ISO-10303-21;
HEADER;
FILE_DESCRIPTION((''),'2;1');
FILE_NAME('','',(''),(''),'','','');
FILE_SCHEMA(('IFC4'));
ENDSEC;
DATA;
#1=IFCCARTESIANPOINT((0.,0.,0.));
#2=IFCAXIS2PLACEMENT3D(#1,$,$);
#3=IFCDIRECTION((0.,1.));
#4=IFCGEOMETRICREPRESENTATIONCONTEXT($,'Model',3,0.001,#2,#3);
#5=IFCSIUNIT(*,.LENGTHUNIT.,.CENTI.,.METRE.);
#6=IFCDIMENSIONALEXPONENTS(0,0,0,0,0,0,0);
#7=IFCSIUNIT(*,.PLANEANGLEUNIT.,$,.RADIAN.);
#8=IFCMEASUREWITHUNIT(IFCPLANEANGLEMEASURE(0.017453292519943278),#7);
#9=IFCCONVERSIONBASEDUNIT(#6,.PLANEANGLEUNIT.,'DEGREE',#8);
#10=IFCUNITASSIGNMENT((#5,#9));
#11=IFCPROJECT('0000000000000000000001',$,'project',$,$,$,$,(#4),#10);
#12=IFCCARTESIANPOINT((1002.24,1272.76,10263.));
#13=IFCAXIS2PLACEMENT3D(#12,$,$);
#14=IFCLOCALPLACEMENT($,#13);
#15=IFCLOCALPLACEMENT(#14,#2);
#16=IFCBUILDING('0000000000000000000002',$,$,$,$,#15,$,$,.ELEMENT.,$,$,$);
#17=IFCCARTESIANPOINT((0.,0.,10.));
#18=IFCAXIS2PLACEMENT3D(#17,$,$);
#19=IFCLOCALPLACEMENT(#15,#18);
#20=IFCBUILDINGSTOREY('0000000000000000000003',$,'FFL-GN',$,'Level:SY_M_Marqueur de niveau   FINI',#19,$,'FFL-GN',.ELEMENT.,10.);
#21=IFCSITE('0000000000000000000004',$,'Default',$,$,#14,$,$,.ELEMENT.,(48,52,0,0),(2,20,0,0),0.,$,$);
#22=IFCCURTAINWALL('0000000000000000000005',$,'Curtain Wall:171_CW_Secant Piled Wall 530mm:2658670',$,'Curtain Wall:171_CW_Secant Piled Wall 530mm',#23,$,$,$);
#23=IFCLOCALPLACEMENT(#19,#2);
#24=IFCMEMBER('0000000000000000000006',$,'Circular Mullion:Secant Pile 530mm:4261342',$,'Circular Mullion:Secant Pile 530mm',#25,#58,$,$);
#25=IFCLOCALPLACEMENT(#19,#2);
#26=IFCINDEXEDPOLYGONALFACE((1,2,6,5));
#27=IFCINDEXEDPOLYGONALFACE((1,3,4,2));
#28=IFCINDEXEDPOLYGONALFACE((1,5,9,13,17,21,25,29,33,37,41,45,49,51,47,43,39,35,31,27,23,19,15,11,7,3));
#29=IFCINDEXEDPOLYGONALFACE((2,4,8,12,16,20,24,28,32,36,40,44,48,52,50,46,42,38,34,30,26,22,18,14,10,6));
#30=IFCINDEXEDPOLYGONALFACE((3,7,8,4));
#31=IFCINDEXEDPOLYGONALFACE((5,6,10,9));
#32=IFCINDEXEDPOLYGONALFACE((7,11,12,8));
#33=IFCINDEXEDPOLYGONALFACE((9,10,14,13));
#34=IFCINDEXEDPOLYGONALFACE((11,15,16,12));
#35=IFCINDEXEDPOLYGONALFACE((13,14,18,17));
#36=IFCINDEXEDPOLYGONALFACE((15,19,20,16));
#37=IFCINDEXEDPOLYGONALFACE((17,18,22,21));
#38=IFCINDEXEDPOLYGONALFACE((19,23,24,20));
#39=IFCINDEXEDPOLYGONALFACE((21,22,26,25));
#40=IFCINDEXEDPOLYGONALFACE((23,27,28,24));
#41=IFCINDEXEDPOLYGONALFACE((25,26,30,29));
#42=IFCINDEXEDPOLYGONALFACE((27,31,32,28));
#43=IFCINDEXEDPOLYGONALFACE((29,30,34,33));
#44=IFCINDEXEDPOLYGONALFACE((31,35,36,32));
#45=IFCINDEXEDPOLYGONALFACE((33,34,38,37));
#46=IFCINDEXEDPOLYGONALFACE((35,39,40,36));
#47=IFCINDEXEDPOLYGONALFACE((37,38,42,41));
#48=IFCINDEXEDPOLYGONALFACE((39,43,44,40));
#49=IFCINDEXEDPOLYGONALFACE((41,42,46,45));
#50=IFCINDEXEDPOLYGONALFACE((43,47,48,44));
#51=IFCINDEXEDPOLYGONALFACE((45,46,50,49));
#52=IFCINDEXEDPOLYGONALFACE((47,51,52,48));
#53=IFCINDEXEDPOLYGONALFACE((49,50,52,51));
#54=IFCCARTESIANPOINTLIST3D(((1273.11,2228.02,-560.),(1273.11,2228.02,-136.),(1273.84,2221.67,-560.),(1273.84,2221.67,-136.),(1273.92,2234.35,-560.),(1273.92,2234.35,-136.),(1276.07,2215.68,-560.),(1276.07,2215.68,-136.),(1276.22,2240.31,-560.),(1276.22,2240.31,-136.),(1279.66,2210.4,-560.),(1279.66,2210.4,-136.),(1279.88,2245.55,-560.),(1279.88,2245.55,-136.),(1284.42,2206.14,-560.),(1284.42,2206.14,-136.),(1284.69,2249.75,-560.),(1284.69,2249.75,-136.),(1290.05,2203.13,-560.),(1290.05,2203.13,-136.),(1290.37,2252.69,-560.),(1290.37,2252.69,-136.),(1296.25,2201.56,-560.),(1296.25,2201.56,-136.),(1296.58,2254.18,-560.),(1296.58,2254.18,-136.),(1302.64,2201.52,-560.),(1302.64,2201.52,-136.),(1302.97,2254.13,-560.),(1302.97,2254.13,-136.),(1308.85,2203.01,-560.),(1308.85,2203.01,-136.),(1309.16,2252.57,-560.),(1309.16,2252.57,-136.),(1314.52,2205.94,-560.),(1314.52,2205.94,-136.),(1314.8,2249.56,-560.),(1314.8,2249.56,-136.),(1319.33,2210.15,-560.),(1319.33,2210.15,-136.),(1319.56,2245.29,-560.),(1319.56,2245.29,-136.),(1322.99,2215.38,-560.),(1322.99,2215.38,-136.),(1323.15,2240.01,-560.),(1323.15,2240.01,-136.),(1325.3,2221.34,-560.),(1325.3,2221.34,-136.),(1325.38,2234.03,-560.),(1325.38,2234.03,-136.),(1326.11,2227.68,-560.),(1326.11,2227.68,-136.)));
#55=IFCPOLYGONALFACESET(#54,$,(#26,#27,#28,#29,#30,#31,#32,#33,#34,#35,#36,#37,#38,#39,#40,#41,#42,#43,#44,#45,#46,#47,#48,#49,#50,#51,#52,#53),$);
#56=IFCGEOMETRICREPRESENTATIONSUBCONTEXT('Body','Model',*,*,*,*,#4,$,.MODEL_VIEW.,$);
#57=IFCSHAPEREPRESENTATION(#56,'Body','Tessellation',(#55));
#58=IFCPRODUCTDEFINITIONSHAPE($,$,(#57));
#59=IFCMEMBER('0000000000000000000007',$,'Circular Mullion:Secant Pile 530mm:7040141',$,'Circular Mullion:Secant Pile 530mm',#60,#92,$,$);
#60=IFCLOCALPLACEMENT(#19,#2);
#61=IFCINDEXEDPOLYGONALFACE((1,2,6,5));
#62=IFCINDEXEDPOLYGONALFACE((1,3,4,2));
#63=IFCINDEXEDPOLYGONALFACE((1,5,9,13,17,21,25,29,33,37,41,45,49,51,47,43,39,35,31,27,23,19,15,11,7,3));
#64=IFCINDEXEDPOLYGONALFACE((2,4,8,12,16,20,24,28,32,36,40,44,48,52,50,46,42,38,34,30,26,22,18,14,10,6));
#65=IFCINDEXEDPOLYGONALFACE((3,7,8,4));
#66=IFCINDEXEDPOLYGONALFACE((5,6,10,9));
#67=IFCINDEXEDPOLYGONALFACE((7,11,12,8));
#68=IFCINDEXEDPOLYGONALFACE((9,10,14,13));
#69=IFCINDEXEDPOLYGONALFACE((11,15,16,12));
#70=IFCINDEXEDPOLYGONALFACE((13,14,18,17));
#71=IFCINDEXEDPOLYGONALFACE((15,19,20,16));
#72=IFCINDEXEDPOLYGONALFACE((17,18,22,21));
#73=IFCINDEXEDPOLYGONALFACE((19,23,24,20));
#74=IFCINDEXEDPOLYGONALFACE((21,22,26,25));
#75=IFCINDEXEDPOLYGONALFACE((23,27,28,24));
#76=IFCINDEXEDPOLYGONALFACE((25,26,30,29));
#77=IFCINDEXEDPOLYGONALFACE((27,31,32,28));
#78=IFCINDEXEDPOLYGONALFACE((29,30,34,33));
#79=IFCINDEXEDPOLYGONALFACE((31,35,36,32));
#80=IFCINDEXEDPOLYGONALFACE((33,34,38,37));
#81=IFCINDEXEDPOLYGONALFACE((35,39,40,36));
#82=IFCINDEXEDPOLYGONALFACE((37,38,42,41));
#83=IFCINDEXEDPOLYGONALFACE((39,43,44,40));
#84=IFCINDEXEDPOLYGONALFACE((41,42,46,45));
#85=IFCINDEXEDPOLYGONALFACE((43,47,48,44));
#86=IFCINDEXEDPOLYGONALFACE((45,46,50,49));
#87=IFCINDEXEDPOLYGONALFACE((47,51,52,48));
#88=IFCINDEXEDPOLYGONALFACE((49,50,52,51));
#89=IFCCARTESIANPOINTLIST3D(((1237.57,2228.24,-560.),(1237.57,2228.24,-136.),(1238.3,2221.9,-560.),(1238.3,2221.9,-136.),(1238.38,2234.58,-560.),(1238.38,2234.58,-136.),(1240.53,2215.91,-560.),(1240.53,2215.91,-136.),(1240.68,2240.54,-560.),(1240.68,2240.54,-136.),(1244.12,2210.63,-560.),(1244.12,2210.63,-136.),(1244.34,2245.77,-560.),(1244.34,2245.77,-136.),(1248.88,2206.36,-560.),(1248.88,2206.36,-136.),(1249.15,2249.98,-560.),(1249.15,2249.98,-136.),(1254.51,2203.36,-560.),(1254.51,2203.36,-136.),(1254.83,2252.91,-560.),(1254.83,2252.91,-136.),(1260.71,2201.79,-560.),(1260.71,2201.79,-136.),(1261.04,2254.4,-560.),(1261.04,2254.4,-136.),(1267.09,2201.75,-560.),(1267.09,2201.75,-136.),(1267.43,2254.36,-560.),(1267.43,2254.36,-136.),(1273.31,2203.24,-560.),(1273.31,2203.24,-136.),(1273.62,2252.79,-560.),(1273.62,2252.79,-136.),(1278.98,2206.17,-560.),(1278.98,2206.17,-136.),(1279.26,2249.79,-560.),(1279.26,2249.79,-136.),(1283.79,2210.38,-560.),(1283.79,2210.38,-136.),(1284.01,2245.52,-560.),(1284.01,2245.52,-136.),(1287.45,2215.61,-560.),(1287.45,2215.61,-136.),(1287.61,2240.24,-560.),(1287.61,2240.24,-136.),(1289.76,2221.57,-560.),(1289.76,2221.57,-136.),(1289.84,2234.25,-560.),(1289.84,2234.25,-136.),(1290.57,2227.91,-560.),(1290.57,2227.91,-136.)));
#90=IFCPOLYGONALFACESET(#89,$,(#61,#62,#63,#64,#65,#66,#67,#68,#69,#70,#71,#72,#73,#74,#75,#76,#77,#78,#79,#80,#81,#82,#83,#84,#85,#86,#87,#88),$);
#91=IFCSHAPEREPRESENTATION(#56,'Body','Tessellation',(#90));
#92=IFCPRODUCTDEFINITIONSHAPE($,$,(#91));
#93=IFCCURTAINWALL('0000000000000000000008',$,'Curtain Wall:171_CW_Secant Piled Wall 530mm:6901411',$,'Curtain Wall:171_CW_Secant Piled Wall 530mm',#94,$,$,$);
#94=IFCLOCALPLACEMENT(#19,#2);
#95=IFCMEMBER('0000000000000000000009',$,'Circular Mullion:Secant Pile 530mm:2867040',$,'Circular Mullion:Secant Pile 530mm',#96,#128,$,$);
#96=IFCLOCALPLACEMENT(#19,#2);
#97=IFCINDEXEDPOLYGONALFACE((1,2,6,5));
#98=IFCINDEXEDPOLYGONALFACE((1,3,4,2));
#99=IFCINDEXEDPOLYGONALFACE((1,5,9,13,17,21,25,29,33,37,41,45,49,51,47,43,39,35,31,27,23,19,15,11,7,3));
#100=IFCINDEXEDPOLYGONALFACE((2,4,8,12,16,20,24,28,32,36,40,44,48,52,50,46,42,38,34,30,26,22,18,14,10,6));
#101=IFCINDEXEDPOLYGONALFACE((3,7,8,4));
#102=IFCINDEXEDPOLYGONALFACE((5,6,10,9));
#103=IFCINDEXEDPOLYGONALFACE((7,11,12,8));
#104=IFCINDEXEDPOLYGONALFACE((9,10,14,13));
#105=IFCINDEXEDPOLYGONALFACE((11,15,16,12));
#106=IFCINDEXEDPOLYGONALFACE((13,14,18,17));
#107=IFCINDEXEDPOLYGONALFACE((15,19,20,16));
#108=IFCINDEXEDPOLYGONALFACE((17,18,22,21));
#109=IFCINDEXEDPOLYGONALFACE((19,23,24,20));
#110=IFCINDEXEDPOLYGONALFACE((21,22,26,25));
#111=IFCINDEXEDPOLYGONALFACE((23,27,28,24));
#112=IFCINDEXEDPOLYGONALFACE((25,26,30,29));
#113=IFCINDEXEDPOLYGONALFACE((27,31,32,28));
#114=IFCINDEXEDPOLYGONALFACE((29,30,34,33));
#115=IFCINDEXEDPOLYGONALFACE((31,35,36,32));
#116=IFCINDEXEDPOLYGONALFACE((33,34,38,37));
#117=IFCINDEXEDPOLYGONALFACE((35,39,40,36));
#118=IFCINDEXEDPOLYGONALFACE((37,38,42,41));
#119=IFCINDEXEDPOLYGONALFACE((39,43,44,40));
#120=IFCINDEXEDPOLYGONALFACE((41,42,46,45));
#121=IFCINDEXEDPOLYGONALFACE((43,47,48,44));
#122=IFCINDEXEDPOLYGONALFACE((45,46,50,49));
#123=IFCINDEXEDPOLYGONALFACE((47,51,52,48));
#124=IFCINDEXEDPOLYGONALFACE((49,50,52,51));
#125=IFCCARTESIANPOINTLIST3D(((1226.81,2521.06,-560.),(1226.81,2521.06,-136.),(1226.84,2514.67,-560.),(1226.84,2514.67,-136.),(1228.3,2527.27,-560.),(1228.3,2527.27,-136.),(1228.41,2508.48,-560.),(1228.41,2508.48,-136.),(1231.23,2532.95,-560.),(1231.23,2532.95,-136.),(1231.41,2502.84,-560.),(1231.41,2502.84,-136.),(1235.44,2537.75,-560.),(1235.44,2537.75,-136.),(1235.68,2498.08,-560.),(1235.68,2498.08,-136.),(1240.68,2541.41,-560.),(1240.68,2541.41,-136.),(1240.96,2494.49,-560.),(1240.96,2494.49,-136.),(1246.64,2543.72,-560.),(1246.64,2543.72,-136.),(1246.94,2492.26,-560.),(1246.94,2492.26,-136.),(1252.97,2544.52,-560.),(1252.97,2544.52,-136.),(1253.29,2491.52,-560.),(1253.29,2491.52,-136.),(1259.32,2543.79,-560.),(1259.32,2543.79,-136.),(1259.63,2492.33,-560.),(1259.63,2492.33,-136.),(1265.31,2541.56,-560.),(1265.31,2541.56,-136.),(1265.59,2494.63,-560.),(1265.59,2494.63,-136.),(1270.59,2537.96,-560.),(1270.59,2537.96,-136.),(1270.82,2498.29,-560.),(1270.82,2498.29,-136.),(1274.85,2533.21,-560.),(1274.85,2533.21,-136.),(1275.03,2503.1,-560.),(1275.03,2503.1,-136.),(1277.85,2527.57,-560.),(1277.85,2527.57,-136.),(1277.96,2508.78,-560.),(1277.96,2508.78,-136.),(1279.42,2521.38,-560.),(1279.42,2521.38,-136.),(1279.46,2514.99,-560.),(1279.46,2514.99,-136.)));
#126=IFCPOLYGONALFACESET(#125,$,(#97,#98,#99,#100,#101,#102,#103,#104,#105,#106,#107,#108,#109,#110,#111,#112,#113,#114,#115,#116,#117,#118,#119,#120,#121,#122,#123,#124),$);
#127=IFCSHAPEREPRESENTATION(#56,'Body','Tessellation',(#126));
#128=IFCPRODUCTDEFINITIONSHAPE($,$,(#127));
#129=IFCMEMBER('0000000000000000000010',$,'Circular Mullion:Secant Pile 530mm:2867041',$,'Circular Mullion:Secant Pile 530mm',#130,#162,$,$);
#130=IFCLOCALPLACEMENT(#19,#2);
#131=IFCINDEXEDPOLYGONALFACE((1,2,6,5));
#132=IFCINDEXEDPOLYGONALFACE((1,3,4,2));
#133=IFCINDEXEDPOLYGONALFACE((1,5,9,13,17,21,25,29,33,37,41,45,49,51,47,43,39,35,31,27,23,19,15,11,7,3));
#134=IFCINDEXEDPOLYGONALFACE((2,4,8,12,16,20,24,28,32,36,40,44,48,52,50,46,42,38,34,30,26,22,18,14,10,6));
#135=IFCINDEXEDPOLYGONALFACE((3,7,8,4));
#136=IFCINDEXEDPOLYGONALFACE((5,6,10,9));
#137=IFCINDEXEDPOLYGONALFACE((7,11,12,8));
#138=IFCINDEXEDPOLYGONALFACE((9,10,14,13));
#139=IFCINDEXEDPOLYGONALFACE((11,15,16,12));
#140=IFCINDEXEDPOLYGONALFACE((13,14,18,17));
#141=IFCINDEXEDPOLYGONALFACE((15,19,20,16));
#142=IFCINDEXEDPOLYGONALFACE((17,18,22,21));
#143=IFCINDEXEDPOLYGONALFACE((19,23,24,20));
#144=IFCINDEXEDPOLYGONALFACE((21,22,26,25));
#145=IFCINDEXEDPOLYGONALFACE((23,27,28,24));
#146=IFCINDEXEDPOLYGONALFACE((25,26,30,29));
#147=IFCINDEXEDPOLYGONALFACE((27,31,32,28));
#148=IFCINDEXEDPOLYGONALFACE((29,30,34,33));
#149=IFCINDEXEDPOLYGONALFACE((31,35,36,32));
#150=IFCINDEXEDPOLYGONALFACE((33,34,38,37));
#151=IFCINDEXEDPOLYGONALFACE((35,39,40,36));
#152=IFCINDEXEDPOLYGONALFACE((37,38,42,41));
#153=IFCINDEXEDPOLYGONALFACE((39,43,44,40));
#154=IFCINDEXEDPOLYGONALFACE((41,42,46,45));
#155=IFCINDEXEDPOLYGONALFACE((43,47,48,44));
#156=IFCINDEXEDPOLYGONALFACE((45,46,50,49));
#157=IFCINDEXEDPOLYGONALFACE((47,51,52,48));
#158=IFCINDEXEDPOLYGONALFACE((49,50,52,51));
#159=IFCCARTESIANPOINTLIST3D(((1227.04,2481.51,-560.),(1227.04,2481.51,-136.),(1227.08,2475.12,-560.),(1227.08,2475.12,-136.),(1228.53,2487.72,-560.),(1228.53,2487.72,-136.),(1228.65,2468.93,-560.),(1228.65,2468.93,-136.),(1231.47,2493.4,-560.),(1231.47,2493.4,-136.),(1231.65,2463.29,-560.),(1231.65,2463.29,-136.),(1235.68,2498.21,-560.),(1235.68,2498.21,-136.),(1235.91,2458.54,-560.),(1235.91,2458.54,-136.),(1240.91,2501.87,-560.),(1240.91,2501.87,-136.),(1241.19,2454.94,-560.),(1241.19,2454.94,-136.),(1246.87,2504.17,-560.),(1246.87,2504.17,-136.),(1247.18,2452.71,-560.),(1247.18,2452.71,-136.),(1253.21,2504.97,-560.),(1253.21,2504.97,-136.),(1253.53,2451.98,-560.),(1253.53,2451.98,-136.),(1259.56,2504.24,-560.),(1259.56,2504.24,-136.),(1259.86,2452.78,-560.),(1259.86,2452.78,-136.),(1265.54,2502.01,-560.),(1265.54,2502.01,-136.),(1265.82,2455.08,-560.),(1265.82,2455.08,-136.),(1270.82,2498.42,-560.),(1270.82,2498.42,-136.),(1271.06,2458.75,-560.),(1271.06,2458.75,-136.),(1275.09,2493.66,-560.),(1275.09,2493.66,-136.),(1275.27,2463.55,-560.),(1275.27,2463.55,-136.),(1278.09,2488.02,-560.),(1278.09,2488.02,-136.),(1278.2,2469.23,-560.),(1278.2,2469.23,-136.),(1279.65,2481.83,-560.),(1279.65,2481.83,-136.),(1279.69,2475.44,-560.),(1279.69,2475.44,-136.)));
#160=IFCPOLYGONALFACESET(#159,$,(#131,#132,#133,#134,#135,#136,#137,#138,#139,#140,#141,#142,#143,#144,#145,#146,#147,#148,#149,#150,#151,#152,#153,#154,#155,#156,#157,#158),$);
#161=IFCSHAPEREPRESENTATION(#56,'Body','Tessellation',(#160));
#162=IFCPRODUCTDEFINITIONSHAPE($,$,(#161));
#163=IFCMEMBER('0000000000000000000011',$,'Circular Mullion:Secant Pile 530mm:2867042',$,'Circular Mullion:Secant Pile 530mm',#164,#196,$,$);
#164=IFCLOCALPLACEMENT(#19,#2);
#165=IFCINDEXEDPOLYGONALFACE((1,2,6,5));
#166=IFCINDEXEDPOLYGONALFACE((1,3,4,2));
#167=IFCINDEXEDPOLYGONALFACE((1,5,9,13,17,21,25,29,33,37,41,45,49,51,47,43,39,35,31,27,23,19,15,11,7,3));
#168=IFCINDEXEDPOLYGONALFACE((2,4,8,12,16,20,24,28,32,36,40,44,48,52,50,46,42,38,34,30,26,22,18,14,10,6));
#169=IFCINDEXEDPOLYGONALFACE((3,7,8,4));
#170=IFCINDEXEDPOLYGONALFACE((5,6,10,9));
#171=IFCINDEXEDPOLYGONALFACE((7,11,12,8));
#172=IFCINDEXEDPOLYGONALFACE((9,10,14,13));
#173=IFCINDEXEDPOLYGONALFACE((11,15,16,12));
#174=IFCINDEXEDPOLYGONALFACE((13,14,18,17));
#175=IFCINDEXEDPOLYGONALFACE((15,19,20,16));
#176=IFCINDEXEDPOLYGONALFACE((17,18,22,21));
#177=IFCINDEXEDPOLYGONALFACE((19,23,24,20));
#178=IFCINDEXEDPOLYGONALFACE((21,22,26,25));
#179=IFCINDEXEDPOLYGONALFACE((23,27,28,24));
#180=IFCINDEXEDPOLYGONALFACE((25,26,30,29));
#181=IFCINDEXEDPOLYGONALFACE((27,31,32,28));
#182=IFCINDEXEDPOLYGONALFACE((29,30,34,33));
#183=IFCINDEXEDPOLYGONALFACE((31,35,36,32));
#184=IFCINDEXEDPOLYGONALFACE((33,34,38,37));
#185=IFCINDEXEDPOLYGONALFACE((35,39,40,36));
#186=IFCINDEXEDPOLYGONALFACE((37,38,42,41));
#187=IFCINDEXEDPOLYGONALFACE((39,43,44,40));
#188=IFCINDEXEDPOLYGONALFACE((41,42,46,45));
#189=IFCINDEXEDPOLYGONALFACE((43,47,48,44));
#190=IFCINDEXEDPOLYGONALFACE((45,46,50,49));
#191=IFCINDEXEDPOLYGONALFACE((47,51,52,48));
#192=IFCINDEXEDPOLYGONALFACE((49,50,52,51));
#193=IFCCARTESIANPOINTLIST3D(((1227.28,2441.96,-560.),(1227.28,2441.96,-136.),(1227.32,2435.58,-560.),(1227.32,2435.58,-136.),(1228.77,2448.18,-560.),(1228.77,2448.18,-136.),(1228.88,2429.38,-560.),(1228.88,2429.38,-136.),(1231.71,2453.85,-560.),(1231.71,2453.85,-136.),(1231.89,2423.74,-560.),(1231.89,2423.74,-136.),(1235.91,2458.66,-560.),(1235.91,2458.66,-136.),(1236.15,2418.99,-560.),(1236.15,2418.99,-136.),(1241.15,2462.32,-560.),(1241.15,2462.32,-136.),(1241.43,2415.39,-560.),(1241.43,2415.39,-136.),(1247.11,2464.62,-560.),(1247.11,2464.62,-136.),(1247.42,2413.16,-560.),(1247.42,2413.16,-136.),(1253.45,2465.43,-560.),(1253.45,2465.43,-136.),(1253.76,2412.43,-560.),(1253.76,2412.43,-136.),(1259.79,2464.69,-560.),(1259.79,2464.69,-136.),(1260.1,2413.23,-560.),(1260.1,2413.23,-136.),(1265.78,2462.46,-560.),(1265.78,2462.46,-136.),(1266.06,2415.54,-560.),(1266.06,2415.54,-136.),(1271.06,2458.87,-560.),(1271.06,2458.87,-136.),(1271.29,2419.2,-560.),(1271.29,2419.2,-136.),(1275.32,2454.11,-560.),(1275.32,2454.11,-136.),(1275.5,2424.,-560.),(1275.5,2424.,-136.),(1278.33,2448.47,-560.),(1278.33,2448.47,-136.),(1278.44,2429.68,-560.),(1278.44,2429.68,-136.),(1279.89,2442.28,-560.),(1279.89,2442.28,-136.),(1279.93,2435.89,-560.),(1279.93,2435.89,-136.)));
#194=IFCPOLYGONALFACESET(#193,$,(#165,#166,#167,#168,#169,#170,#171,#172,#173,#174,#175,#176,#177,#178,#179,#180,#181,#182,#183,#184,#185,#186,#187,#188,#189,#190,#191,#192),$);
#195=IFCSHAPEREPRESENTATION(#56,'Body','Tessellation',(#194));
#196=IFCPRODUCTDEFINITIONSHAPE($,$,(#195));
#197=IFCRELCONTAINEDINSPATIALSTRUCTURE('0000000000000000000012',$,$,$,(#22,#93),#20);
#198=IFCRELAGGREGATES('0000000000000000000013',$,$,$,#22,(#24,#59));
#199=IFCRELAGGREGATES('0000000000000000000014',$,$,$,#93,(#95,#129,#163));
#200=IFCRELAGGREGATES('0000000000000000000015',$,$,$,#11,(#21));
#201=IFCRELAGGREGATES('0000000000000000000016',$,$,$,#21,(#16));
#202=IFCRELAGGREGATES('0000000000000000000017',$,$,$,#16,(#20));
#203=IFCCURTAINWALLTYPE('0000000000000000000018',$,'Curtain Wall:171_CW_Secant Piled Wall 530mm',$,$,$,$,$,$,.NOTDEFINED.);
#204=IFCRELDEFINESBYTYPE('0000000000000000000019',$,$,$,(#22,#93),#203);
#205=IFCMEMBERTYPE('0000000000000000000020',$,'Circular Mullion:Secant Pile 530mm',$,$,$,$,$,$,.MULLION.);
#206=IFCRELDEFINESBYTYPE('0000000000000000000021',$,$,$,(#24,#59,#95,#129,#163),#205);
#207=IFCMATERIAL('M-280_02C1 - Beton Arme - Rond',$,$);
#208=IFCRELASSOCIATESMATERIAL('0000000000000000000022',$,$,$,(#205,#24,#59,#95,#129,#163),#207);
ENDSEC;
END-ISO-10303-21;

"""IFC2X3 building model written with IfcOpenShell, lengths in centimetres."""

from ifc_helpers import new_model, entity, si_unit, converted_unit, direction, frame, frame_2d, origin, place, context, subcontext, project, spatial, circle, extrude, source, transform, mapped, material, type_object, type_shapes, element, aggregate, save


model = new_model("IFC2X3")

# Units and contexts
model_context = context("Model", 3, precision=0.001, world=origin(), true_north=direction((0.0, 1.0)))
body_context = subcontext(model_context, "Body", "Model", "MODEL_VIEW")
ifc_project = project(units=[si_unit("LENGTHUNIT", "METRE", prefix="CENTI"), converted_unit("PLANEANGLEUNIT", "DEGREE", entity("IfcPlaneAngleMeasure", 0.017453292519943278), si_unit("PLANEANGLEUNIT", "RADIAN"), dimensions=[0, 0, 0, 0, 0, 0, 0])], contexts=[model_context])

# Site, building, storey
site_placement = place(None, frame((1002.24, 1272.76, 10263.0)))
site = spatial("IfcSite", under=ifc_project, at=site_placement, Name="Default", CompositionType="ELEMENT", RefLatitude=(48, 52, 0, 0), RefLongitude=(2, 20, 0, 0), RefElevation=0.0)
building_placement = place(site_placement, origin())
building = spatial("IfcBuilding", under=site, at=building_placement, CompositionType="ELEMENT")
storey_placement = place(building_placement, frame((0.0, 0.0, 10.0)))
storey = spatial("IfcBuildingStorey", under=building, at=storey_placement, Name="FFL-GN", ObjectType="Level:SY_M_Marqueur de niveau   FINI", LongName="FFL-GN", CompositionType="ELEMENT", Elevation=10.0)

# Curtain walls, members
curtain_wall_type = type_object("IfcCurtainWallType", Name="Curtain Wall:171_CW_Secant Piled Wall 530mm", PredefinedType="NOTDEFINED")
ifc_material_1 = material(Name="M-280_02C1 - Beton Arme - Rond")
member_type = type_object("IfcMemberType", Name="Circular Mullion:Secant Pile 530mm", PredefinedType="MULLION", material=ifc_material_1)
shared_shape = source(origin(), body_context, "Body", "SweptSolid", [
    extrude(circle(Radius=26.5, at=frame_2d((0.0, 0.0), x_axis=(1.0, 0.0))), frame((0.0, 0.0, -424.0)), (0.0, 0.0, 1.0), 424.0),
])
type_shapes(member_type, [shared_shape])
curtain_wall_1_placement = place(storey_placement, frame((0.0, 0.0, -10.0)))
curtain_wall_1 = element("IfcCurtainWall", 1, at=curtain_wall_1_placement, inside=storey, type_object=curtain_wall_type, Name="Curtain Wall:171_CW_Secant Piled Wall 530mm:2658670", ObjectType="Curtain Wall:171_CW_Secant Piled Wall 530mm")
member_1_placement = place(curtain_wall_1_placement, frame((1299.61, 2227.85, -550.0), z_axis=(0.0, 0.0, -1.0), x_axis=(-0.99998, 0.006355, 0.0)))
member_1 = element("IfcMember", 2, at=member_1_placement, type_object=member_type, material=ifc_material_1, Name="Circular Mullion:Secant Pile 530mm:4261342", ObjectType="Circular Mullion:Secant Pile 530mm", context=body_context, shape_type="MappedRepresentation", body=[
    mapped(shared_shape, transform((0.0, 0.0, 0.0), scale=1.0)),
])
member_2_placement = place(curtain_wall_1_placement, frame((1264.07, 2228.07, -550.0), z_axis=(0.0, 0.0, -1.0), x_axis=(-0.99998, 0.006355, 0.0)))
member_2 = element("IfcMember", 3, at=member_2_placement, type_object=member_type, material=ifc_material_1, Name="Circular Mullion:Secant Pile 530mm:7040141", ObjectType="Circular Mullion:Secant Pile 530mm", context=body_context, shape_type="MappedRepresentation", body=[
    mapped(shared_shape, transform((0.0, 0.0, 0.0), scale=1.0)),
])
aggregate(curtain_wall_1, [member_1, member_2])
curtain_wall_2_placement = place(storey_placement, frame((0.0, 0.0, -10.0)))
curtain_wall_2 = element("IfcCurtainWall", 4, at=curtain_wall_2_placement, inside=storey, type_object=curtain_wall_type, Name="Curtain Wall:171_CW_Secant Piled Wall 530mm:6901411", ObjectType="Curtain Wall:171_CW_Secant Piled Wall 530mm")
member_3_placement = place(curtain_wall_2_placement, frame((1253.13, 2518.02, -550.0), z_axis=(0.0, 0.0, -1.0), x_axis=(0.005975, -0.999982, 0.0)))
member_3 = element("IfcMember", 5, at=member_3_placement, type_object=member_type, material=ifc_material_1, Name="Circular Mullion:Secant Pile 530mm:2867040", ObjectType="Circular Mullion:Secant Pile 530mm", context=body_context, shape_type="MappedRepresentation", body=[
    mapped(shared_shape, transform((0.0, 0.0, 0.0), scale=1.0)),
])
member_4_placement = place(curtain_wall_2_placement, frame((1253.37, 2478.48, -550.0), z_axis=(0.0, 0.0, -1.0), x_axis=(0.005975, -0.999982, 0.0)))
member_4 = element("IfcMember", 6, at=member_4_placement, type_object=member_type, material=ifc_material_1, Name="Circular Mullion:Secant Pile 530mm:2867041", ObjectType="Circular Mullion:Secant Pile 530mm", context=body_context, shape_type="MappedRepresentation", body=[
    mapped(shared_shape, transform((0.0, 0.0, 0.0), scale=1.0)),
])
member_5_placement = place(curtain_wall_2_placement, frame((1253.6, 2438.93, -550.0), z_axis=(0.0, 0.0, -1.0), x_axis=(0.005975, -0.999982, 0.0)))
member_5 = element("IfcMember", 7, at=member_5_placement, type_object=member_type, material=ifc_material_1, Name="Circular Mullion:Secant Pile 530mm:2867042", ObjectType="Circular Mullion:Secant Pile 530mm", context=body_context, shape_type="MappedRepresentation", body=[
    mapped(shared_shape, transform((0.0, 0.0, 0.0), scale=1.0)),
])
aggregate(curtain_wall_2, [member_3, member_4, member_5])

save(model, "model.ifc")
